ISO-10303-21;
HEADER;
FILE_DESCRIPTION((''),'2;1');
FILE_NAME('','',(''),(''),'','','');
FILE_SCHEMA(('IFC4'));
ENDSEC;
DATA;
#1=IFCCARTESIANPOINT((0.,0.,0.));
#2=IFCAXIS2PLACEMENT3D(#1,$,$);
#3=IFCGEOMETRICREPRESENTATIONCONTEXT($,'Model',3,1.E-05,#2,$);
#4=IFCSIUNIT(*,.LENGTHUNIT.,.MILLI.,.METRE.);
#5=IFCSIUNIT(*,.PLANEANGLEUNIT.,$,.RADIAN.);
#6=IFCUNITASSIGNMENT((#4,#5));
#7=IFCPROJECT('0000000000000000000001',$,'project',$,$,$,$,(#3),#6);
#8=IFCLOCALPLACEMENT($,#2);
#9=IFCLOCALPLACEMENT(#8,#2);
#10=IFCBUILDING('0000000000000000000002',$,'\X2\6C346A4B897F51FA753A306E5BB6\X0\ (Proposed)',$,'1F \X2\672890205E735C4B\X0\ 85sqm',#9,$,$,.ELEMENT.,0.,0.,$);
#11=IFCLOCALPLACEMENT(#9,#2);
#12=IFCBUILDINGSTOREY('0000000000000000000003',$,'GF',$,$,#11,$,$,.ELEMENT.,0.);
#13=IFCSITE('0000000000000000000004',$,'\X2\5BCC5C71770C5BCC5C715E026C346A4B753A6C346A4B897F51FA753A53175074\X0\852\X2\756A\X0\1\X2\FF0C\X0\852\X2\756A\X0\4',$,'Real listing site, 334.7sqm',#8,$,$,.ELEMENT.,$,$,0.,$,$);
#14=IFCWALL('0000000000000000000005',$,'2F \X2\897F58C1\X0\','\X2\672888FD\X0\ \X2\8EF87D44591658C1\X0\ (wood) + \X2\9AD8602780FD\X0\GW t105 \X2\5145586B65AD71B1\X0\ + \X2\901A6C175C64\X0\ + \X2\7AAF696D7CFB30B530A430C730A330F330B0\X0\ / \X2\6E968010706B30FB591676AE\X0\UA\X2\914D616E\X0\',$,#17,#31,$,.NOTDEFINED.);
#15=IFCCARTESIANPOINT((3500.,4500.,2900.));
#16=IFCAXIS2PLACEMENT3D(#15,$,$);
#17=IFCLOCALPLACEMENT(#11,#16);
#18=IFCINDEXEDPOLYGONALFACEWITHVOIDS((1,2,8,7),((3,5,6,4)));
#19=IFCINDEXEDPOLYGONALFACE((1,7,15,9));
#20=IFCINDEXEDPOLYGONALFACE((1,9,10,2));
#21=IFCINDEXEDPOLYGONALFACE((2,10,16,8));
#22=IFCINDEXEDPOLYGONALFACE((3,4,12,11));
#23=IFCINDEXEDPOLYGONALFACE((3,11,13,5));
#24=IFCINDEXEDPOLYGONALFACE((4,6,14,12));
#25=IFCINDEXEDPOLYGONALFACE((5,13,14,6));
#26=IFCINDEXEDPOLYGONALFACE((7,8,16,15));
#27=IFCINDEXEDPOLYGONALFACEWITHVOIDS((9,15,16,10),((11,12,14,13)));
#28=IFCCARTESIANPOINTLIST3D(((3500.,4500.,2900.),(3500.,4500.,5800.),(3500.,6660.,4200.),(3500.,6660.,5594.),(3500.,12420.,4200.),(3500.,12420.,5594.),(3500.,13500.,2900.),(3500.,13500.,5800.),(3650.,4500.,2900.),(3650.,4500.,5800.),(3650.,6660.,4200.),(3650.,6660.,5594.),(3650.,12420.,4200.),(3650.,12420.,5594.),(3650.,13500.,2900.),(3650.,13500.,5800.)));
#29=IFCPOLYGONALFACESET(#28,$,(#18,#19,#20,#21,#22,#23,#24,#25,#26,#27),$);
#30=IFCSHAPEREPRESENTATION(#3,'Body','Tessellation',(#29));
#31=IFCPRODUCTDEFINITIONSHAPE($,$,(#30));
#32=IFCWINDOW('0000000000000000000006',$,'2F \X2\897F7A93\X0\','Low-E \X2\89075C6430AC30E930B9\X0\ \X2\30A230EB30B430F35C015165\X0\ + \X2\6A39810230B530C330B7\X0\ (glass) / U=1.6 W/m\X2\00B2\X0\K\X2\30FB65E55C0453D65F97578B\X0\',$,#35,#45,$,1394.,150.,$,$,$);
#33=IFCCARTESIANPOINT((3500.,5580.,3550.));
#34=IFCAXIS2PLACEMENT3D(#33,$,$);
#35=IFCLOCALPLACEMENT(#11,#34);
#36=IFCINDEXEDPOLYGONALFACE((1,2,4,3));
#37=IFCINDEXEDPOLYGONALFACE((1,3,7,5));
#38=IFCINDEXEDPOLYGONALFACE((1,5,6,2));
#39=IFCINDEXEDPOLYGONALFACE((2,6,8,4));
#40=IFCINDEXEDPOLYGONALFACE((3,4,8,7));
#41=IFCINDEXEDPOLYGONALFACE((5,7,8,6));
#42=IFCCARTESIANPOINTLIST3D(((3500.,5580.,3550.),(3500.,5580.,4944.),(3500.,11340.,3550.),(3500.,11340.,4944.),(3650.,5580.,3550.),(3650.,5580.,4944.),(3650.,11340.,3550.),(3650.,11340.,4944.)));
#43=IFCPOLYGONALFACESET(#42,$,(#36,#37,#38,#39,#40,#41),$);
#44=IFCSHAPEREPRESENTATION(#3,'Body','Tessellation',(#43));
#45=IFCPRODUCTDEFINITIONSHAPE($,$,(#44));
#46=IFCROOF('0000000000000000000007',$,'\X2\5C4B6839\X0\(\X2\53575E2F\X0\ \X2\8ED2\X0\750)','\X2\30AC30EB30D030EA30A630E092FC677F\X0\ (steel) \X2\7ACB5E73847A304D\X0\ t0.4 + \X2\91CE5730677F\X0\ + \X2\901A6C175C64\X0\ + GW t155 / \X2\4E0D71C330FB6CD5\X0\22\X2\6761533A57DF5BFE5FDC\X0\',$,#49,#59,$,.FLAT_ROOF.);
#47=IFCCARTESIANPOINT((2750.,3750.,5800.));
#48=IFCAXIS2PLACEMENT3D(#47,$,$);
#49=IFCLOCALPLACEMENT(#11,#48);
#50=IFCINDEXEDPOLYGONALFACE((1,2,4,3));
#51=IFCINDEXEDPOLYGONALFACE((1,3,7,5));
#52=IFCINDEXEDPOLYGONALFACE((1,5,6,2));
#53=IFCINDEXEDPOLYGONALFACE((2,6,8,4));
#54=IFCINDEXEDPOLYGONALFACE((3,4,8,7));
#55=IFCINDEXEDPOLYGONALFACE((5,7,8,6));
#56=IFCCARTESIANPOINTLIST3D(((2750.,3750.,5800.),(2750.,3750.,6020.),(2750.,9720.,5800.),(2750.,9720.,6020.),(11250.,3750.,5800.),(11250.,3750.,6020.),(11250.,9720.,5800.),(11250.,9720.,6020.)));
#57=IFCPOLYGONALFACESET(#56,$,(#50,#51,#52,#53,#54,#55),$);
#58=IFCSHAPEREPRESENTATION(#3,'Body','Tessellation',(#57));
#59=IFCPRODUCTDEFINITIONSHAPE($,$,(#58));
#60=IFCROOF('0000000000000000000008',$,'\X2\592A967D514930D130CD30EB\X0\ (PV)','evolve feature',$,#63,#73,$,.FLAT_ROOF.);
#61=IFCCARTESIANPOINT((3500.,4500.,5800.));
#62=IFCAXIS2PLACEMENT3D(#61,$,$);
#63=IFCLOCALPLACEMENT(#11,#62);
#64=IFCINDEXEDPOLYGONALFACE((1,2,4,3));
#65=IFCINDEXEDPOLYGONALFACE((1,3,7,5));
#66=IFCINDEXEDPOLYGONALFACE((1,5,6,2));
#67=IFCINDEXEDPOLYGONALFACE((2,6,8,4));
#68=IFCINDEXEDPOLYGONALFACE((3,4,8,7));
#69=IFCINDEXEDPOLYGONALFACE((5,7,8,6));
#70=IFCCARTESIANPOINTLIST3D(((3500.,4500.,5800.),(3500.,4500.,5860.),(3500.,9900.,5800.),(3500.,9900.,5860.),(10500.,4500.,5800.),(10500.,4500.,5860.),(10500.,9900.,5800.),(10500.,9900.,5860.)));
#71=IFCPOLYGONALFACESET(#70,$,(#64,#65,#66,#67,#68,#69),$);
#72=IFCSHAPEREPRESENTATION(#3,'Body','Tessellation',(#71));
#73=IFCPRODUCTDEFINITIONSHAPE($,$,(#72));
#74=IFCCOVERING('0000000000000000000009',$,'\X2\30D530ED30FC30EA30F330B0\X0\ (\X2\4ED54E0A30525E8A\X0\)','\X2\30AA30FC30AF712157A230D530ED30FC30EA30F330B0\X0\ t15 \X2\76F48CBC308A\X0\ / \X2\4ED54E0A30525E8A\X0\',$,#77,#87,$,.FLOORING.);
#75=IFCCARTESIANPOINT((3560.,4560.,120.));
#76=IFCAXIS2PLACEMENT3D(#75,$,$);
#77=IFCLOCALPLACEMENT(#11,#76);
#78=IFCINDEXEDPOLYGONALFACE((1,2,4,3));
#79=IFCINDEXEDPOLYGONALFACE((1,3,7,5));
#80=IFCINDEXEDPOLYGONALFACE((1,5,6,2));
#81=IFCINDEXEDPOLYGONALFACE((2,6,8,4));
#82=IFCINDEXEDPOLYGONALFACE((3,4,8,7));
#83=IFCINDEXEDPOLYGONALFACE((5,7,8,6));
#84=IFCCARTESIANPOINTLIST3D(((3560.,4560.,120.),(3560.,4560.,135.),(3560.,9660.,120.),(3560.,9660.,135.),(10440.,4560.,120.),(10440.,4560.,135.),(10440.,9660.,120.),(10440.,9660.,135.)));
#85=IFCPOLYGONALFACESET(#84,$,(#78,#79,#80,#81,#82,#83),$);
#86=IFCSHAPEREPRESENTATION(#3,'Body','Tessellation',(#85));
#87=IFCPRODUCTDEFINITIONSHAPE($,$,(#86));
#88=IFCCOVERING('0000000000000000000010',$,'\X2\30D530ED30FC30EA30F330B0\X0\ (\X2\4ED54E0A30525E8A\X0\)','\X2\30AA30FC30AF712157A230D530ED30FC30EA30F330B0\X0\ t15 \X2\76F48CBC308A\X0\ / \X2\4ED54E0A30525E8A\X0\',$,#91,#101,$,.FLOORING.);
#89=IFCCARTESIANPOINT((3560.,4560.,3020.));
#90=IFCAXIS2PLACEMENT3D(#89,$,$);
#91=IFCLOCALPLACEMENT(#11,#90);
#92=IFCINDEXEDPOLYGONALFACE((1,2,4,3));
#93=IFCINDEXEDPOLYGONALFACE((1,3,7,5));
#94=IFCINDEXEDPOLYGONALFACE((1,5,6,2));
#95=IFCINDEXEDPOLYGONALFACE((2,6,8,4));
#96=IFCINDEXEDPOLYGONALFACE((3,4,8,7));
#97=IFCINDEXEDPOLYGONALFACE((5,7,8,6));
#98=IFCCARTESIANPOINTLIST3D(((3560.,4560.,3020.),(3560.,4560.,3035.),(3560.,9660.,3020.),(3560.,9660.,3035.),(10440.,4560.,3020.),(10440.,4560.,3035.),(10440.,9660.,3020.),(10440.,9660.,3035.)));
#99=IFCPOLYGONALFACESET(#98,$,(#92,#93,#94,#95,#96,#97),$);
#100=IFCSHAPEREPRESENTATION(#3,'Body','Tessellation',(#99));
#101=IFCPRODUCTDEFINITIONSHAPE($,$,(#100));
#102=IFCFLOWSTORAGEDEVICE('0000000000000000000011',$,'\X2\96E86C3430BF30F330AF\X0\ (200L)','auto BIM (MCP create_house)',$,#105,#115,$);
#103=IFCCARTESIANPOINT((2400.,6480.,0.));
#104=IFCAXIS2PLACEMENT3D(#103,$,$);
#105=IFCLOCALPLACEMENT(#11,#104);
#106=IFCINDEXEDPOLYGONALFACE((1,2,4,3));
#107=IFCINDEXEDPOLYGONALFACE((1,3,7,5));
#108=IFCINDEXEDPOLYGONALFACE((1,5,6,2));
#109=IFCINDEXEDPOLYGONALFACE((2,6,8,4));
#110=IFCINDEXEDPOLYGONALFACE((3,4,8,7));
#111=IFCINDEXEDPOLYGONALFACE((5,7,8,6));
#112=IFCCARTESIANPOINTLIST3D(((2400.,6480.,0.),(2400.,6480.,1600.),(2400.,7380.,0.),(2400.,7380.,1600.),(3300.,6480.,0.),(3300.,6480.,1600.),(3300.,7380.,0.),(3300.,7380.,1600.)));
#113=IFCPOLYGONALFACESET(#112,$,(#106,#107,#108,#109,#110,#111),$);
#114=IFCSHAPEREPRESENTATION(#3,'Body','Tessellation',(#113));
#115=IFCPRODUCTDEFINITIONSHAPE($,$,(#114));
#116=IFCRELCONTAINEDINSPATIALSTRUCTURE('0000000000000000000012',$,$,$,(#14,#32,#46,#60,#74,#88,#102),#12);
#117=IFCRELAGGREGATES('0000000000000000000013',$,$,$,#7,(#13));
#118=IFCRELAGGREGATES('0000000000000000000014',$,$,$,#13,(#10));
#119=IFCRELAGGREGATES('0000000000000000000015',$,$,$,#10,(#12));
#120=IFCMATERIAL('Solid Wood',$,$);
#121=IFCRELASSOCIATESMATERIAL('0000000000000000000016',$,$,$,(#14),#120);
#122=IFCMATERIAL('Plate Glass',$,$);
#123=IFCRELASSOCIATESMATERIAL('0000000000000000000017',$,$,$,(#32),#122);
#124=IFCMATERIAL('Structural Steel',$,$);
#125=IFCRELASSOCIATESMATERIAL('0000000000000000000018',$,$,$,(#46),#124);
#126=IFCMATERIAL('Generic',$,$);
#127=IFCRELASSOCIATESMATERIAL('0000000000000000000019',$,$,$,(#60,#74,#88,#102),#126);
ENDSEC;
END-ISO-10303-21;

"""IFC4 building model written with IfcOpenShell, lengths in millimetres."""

from ifc_helpers import new_model, si_unit, frame, frame_2d, origin, place, context, project, spatial, rectangle, extrude, material, element, fill, save


model = new_model("IFC4")

# Units and contexts
model_context = context("Model", 3, precision=1e-05, world=origin())
ifc_project = project(units=[si_unit("LENGTHUNIT", "METRE", prefix="MILLI"), si_unit("PLANEANGLEUNIT", "RADIAN")], contexts=[model_context])

# Site, building, storey
site_placement = place(None, origin())
site = spatial("IfcSite", under=ifc_project, at=site_placement, Name="富山県富山市水橋町水橋西出町北側852番1，852番4", ObjectType="Real listing site, 334.7sqm", CompositionType="ELEMENT", RefElevation=0.0)
building_placement = place(site_placement, origin())
building = spatial("IfcBuilding", under=site, at=building_placement, Name="水橋西出町の家 (Proposed)", ObjectType="1F 木造平屋 85sqm", CompositionType="ELEMENT", ElevationOfRefHeight=0.0, ElevationOfTerrain=0.0)
storey_placement = place(building_placement, origin())
storey = spatial("IfcBuildingStorey", under=building, at=storey_placement, Name="GF", CompositionType="ELEMENT", Elevation=0.0)

# Shared definitions
ifc_material_1 = material(Name="Solid Wood")
ifc_material_2 = material(Name="Generic")

# Shared definitions
ifc_material_3 = material(Name="Plate Glass")

# Wall, opening, window
wall_1_placement = place(storey_placement, frame((3500.0, 4500.0, 2900.0)))
wall_1 = element("IfcWall", 1, at=wall_1_placement, inside=storey, material=ifc_material_1, Name="2F 西壁", Description="木製 軸組外壁 (wood) + 高性能GW t105 充填断熱 + 通気層 + 窯業系サイディング / 準耐火・外皮UA配慮", PredefinedType="NOTDEFINED", context=model_context, shape_type="SweptSolid", body=[
    extrude(rectangle(XDim=150.0, YDim=9000.0, at=frame_2d((75.0, 4500.0))), frame((3500.0, 4500.0, 2900.0)), (0.0, 0.0, 1.0), 2900.0),
])
opening_1_placement = place(storey_placement, frame((3500.0, 5580.0, 3550.0)))
opening_1 = element("IfcOpeningElement", 2, at=opening_1_placement, cuts=wall_1, PredefinedType="NOTDEFINED", context=model_context, shape_type="SweptSolid", body=[
    extrude(rectangle(XDim=150.0, YDim=5760.0, at=frame_2d((75.0, 2880.0))), frame((3500.0, 5580.0, 3550.0)), (0.0, 0.0, 1.0), 1394.0),
])
window_1_placement = place(storey_placement, frame((3500.0, 5580.0, 3550.0)))
window_1 = element("IfcWindow", 3, at=window_1_placement, inside=storey, material=ifc_material_3, Name="2F 西窓", Description="Low-E 複層ガラス アルゴン封入 + 樹脂サッシ (glass) / U=1.6 W/m²K・日射取得型", OverallHeight=1394.0, OverallWidth=150.0, context=model_context, shape_type="SweptSolid", body=[
    extrude(rectangle(XDim=150.0, YDim=5760.0, at=frame_2d((75.0, 2880.0))), frame((3500.0, 5580.0, 3550.0)), (0.0, 0.0, 1.0), 1394.0),
])
fill(opening_1, window_1)

# Roofs
ifc_material_4 = material(Name="Structural Steel")
for number, where, name in (
    (4, (2750.0, 3750.0, 5800.0), "屋根(南帯 軒750)"),
):
    element("IfcRoof", number, at=place(storey_placement, frame(where)), inside=storey, material=ifc_material_4, Name=name, Description="ガルバリウム鋼板 (steel) 立平葺き t0.4 + 野地板 + 通気層 + GW t155 / 不燃・法22条区域対応", PredefinedType="FLAT_ROOF", context=model_context, shape_type="SweptSolid", body=[
        extrude(rectangle(XDim=8500.0, YDim=5970.0, at=frame_2d((4250.0, 2985.0))), frame((2750.0, 3750.0, 5800.0)), (0.0, 0.0, 1.0), 220.0),
    ])
roof_placement = place(storey_placement, frame((3500.0, 4500.0, 5800.0)))
element("IfcRoof", 5, at=roof_placement, inside=storey, material=ifc_material_2, Name="太陽光パネル (PV)", Description="evolve feature", PredefinedType="FLAT_ROOF", context=model_context, shape_type="SweptSolid", body=[
    extrude(rectangle(XDim=7000.0, YDim=5400.0, at=frame_2d((3500.0, 2700.0))), frame((3500.0, 4500.0, 5800.0)), (0.0, 0.0, 1.0), 60.0),
])

# Coverings
covering_1_placement = place(storey_placement, frame((3560.0, 4560.0, 120.0)))
element("IfcCovering", 6, at=covering_1_placement, inside=storey, material=ifc_material_2, Name="フローリング (仕上げ床)", Description="オーク無垢フローリング t15 直貼り / 仕上げ床", PredefinedType="FLOORING", context=model_context, shape_type="SweptSolid", body=[
    extrude(rectangle(XDim=6880.0, YDim=5100.0, at=frame_2d((3440.0, 2550.0))), frame((3560.0, 4560.0, 120.0)), (0.0, 0.0, 1.0), 15.0),
])
covering_2_placement = place(storey_placement, frame((3560.0, 4560.0, 3020.0)))
element("IfcCovering", 7, at=covering_2_placement, inside=storey, material=ifc_material_2, Name="フローリング (仕上げ床)", Description="オーク無垢フローリング t15 直貼り / 仕上げ床", PredefinedType="FLOORING", context=model_context, shape_type="SweptSolid", body=[
    extrude(rectangle(XDim=6880.0, YDim=5100.0, at=frame_2d((3440.0, 2550.0))), frame((3560.0, 4560.0, 3020.0)), (0.0, 0.0, 1.0), 15.0),
])

# Flow storage device
flow_storage_device_placement = place(storey_placement, frame((2400.0, 6480.0, 0.0)))
element("IfcFlowStorageDevice", 8, at=flow_storage_device_placement, inside=storey, material=ifc_material_2, Name="雨水タンク (200L)", Description="auto BIM (MCP create_house)", context=model_context, shape_type="SweptSolid", body=[
    extrude(rectangle(XDim=900.0, YDim=900.0, at=frame_2d((450.0, 450.0))), frame((2400.0, 6480.0, 0.0)), (0.0, 0.0, 1.0), 1600.0),
])

save(model, "model.ifc")
